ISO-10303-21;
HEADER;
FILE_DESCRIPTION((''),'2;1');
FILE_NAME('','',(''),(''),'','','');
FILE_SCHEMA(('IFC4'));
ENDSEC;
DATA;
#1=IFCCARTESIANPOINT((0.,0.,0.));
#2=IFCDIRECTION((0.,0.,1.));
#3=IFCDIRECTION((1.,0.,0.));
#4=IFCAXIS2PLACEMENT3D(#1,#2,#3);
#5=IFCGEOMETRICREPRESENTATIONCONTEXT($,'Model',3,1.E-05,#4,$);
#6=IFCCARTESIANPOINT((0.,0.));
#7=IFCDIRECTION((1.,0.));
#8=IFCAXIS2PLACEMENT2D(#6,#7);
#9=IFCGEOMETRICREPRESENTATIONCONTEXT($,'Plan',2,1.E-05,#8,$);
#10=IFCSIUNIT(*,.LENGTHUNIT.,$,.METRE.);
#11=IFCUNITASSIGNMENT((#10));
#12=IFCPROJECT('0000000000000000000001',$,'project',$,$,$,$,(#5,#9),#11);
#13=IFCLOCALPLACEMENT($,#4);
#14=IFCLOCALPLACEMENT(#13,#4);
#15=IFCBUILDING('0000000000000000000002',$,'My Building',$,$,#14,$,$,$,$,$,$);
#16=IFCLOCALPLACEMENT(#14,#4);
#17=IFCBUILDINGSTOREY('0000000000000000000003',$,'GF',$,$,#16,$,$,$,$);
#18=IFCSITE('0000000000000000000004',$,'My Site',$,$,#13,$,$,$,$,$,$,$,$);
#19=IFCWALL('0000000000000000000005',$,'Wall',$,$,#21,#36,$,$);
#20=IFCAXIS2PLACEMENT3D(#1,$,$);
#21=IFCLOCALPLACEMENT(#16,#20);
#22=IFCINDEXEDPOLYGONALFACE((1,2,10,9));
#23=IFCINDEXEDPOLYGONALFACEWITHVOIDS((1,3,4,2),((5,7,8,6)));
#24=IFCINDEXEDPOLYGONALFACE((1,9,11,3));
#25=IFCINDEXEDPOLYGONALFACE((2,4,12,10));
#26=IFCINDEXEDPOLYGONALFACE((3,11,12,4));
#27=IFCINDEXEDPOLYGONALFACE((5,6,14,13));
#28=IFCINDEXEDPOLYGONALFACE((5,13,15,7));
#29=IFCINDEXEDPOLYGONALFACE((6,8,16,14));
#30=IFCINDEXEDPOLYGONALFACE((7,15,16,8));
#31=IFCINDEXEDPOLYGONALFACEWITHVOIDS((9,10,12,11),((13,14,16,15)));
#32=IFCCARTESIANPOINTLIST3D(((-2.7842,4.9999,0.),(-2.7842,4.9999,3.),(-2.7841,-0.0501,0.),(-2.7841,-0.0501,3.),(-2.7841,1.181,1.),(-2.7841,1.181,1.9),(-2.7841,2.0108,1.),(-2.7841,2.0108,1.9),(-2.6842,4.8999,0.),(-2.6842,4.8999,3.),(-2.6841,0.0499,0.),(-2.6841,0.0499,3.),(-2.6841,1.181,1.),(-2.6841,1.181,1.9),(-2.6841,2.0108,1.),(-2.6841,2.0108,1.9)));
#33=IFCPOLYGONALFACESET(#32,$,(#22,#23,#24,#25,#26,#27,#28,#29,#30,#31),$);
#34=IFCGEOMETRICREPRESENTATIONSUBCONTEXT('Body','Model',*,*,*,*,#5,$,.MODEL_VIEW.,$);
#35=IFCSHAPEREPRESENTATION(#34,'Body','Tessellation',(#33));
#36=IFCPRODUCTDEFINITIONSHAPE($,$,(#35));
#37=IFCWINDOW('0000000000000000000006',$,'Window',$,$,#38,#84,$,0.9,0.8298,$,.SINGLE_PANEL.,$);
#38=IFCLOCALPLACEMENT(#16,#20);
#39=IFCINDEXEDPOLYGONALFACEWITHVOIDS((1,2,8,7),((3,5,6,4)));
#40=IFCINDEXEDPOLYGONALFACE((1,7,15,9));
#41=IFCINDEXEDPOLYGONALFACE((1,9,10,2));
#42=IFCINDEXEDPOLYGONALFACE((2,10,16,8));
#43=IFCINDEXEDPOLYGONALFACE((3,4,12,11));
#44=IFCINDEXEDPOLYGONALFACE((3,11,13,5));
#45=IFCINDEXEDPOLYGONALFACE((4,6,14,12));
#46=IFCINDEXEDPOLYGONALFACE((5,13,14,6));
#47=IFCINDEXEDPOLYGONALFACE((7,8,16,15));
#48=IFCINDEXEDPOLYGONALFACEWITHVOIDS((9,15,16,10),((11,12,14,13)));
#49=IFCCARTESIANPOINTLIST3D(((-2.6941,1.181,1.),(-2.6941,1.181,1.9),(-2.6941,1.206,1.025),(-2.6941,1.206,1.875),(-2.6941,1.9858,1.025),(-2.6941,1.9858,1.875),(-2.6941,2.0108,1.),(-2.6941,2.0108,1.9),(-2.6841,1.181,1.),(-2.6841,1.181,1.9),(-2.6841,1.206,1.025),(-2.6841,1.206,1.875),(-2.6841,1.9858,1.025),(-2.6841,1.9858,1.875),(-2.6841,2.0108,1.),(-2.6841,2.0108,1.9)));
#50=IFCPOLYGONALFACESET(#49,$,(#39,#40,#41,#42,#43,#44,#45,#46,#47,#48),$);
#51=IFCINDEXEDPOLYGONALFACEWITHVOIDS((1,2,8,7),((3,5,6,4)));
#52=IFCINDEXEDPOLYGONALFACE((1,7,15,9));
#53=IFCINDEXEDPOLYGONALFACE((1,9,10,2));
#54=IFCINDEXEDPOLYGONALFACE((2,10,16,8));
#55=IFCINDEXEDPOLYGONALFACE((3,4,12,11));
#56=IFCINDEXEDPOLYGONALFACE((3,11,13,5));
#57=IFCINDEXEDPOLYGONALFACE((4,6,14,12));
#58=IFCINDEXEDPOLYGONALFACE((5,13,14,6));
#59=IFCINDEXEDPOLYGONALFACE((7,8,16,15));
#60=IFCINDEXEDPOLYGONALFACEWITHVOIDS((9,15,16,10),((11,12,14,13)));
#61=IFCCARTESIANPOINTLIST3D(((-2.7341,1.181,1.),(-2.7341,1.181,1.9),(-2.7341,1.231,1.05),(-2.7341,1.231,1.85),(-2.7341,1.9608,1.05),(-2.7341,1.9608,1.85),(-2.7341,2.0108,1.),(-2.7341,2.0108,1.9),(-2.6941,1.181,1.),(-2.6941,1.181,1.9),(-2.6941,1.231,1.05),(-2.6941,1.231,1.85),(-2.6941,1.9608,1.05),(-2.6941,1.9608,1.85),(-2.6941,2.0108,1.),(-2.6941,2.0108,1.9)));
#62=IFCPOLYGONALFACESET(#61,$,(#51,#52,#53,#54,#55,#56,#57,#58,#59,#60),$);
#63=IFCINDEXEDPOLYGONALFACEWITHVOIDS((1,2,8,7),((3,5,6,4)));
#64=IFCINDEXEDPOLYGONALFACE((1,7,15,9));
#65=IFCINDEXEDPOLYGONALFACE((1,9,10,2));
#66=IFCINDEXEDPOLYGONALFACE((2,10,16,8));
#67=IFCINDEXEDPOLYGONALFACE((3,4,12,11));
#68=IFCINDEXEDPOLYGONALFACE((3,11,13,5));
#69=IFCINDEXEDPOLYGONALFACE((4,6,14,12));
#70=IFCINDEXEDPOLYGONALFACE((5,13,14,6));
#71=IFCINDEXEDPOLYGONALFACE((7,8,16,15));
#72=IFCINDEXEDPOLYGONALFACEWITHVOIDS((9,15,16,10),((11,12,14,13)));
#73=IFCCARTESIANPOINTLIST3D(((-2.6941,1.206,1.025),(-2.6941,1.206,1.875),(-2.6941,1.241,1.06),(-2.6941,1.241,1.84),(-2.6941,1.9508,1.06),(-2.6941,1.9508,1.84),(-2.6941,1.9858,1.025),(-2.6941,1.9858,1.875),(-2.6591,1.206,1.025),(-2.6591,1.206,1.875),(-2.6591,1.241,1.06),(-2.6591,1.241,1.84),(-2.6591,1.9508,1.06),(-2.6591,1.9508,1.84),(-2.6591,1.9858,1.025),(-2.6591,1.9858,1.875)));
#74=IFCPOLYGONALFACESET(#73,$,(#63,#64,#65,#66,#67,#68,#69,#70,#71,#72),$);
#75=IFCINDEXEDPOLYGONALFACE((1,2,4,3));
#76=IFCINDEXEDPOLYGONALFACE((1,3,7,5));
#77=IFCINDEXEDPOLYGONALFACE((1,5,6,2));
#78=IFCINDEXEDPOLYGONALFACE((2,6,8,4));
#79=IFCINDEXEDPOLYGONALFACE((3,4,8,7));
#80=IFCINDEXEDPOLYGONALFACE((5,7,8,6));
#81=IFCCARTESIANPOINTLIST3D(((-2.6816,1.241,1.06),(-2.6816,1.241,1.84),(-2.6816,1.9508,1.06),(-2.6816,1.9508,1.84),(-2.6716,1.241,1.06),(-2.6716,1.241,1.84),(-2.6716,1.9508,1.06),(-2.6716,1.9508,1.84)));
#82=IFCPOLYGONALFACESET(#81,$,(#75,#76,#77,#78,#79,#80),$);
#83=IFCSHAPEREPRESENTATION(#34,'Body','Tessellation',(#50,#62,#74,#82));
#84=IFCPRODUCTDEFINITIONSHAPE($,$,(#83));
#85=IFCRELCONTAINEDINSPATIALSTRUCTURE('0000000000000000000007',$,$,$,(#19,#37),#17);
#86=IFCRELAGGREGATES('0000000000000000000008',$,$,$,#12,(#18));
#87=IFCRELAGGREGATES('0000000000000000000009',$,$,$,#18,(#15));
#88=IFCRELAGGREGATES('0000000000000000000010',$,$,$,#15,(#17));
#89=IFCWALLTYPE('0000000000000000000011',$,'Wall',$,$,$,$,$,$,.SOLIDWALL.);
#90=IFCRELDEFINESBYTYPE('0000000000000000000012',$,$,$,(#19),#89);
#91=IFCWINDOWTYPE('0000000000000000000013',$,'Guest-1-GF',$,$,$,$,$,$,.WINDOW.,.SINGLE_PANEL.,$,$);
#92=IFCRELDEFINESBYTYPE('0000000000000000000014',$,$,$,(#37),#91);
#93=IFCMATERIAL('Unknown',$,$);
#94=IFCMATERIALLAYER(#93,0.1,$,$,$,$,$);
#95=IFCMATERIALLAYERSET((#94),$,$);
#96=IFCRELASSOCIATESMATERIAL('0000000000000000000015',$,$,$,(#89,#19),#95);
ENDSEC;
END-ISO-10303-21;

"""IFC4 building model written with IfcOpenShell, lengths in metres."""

from ifc_helpers import new_model, entity, si_unit, frame, origin_with_axes, origin_2d_with_axis, place, context, subcontext, project, spatial, line, indexed_curve, outline, extrude, shape, source, transform, mapped, material, layer, layer_set, layer_usage, type_object, type_shapes, element, fill, save


model = new_model("IFC4")

# Units and contexts
model_context = context("Model", 3, precision=1e-05, world=origin_with_axes())
plan_context = context("Plan", 2, precision=1e-05, world=origin_2d_with_axis())
body_context_1 = subcontext(model_context, "Body", "Model", "MODEL_VIEW")
body_context_2 = subcontext(plan_context, "Body", "Plan", "PLAN_VIEW")
ifc_project = project(units=[si_unit("LENGTHUNIT", "METRE")], contexts=[model_context, plan_context])

# Site, building, storey
site_placement = place(None, origin_with_axes())
site = spatial("IfcSite", under=ifc_project, at=site_placement, Name="My Site")
building_placement = place(site_placement, origin_with_axes())
building = spatial("IfcBuilding", under=site, at=building_placement, Name="My Building")
storey_placement = place(building_placement, origin_with_axes())
storey = spatial("IfcBuildingStorey", under=building, at=storey_placement, Name="GF")

# Shared definitions
ifc_material_1 = material(Name="Unknown")

# Shared definitions
ifc_layer_1 = layer(ifc_material_1, 0.1)
ifc_layer_set_1 = layer_set([ifc_layer_1])
wall_type = type_object("IfcWallType", Name="Wall", PredefinedType="SOLIDWALL", material=ifc_layer_set_1)

# Wall, opening, window
ifc_layer_usage_1 = layer_usage(ifc_layer_set_1, "AXIS2", "POSITIVE", 0.0)
wall_1_placement = place(storey_placement, frame((-2.7842, 4.9999, 0.0), z_axis=(0.0, 0.0, 1.0), x_axis=(0.0, -1.0, 0.0)))
wall_1 = element("IfcWall", 1, at=wall_1_placement, inside=storey, type_object=wall_type, material=ifc_layer_usage_1, Name="Wall", context=body_context_1, shape_type="SweptSolid", body=[
    extrude(outline(indexed_curve([(0.0, 0.0), (0.1, 0.1), (4.95, 0.1), (5.05, 0.0)], segments=[line(1, 2, 3, 4, 1)])), origin_with_axes(), (0.0, 0.0, 1.0), 3.0),
])
shared_shape_1 = source(origin_with_axes(), body_context_1, "Body", "SweptSolid", [
    extrude(outline(indexed_curve([(0.0, 0.0), (0.8298, 0.0), (0.8298, 0.9), (0.0, 0.9)], segments=[line(1, 2, 3, 4, 1)])), frame((0.0, -0.6, 0.0), z_axis=(0.0, -1.0, 0.0), x_axis=(1.0, 0.0, 0.0)), (0.0, 0.0, -1.0), 1.2),
])
opening_1_placement = place(wall_1_placement, frame((2.989, 0.0, 1.0), z_axis=(0.0, 0.0, 1.0), x_axis=(1.0, 0.0, 0.0)))
opening_1 = element("IfcOpeningElement", 2, at=opening_1_placement, cuts=wall_1, PredefinedType="OPENING", context=body_context_1, shape_type="MappedRepresentation", body=[
    mapped(shared_shape_1, transform((0.0, 0.0, 0.0), x_axis=(1.0, 0.0, 0.0), y_axis=(0.0, 1.0, 0.0), z_axis=(0.0, 0.0, 1.0), scale=1.0)),
])
window_type_1 = type_object("IfcWindowType", Name="Guest-1-GF", PartitioningType="SINGLE_PANEL", PredefinedType="WINDOW")
shared_shape_2 = source(origin_with_axes(), body_context_1, "Body", "SweptSolid", [
    extrude(outline(indexed_curve([(0.0, 0.0), (0.8298, 0.0), (0.8298, 0.9), (0.0, 0.9)], segments=[line(1, 2, 3, 4, 1)]), holes=[indexed_curve([(0.025, 0.025), (0.8048, 0.025), (0.8048, 0.875), (0.025, 0.875)], segments=[line(1, 2, 3, 4, 1)])]), frame((0.0, 0.09, 0.0), z_axis=(0.0, -1.0, 0.0), x_axis=(1.0, 0.0, 0.0)), (0.0, 0.0, -1.0), 0.01),
    extrude(outline(indexed_curve([(0.0, 0.0), (0.8298, 0.0), (0.8298, 0.9), (0.0, 0.9)], segments=[line(1, 2, 3, 4, 1)]), holes=[indexed_curve([(0.05, 0.05), (0.7798, 0.05), (0.7798, 0.85), (0.05, 0.85)], segments=[line(1, 2, 3, 4, 1)])]), frame((0.0, 0.05, 0.0), z_axis=(0.0, -1.0, 0.0), x_axis=(1.0, 0.0, 0.0)), (0.0, 0.0, -1.0), 0.04),
    extrude(outline(indexed_curve([(0.0, 0.0), (0.7798, 0.0), (0.7798, 0.85), (0.0, 0.85)], segments=[line(1, 2, 3, 4, 1)]), holes=[indexed_curve([(0.035, 0.035), (0.7448, 0.035), (0.7448, 0.815), (0.035, 0.815)], segments=[line(1, 2, 3, 4, 1)])]), frame((0.025, 0.09, 0.025), z_axis=(0.0, -1.0, 0.0), x_axis=(1.0, 0.0, 0.0)), (0.0, 0.0, -1.0), 0.035),
    extrude(outline(indexed_curve([(0.035, 0.035), (0.7448, 0.035), (0.7448, 0.815), (0.035, 0.815)], segments=[line(1, 2, 3, 4, 1)])), frame((0.025, 0.1025, 0.025), z_axis=(0.0, -1.0, 0.0), x_axis=(1.0, 0.0, 0.0)), (0.0, 0.0, -1.0), 0.01),
])
shared_shape_3 = source(origin_with_axes(), body_context_2, "Body", "Curve2D", [
    entity("IfcIndexedPolyCurve", entity("IfcCartesianPointList2D", [[0.05, 0.05], [0.7798, 0.05]])),
    entity("IfcIndexedPolyCurve", entity("IfcCartesianPointList2D", [[0.0, 0.1], [0.025, 0.1], [0.025, 0.09], [0.05, 0.09], [0.05, 0.05], [0.0, 0.05]]), [entity("IfcLineIndex", [1, 2, 3, 4, 5, 6, 1])]),
    entity("IfcIndexedPolyCurve", entity("IfcCartesianPointList2D", [[0.8298, 0.1], [0.8048, 0.1], [0.8048, 0.09], [0.7798, 0.09], [0.7798, 0.05], [0.8298, 0.05]]), [entity("IfcLineIndex", [1, 2, 3, 4, 5, 6, 1])]),
    entity("IfcIndexedPolyCurve", entity("IfcCartesianPointList2D", [[0.025, 0.09], [0.06, 0.09], [0.06, 0.125], [0.025, 0.125]]), [entity("IfcLineIndex", [1, 2, 3, 4, 1])]),
    entity("IfcIndexedPolyCurve", entity("IfcCartesianPointList2D", [[0.8048, 0.09], [0.7698, 0.09], [0.7698, 0.125], [0.8048, 0.125]]), [entity("IfcLineIndex", [1, 2, 3, 4, 1])]),
    entity("IfcIndexedPolyCurve", entity("IfcCartesianPointList2D", [[0.06, 0.09], [0.7698, 0.09]])),
    entity("IfcIndexedPolyCurve", entity("IfcCartesianPointList2D", [[0.06, 0.125], [0.7698, 0.125]])),
    entity("IfcIndexedPolyCurve", entity("IfcCartesianPointList2D", [[0.06, 0.1075], [0.7698, 0.1075]])),
])
type_shapes(window_type_1, [shared_shape_2, shared_shape_3])
window_1_placement = place(opening_1_placement, frame((0.0, 0.0, 0.0), z_axis=(0.0, 0.0, 1.0), x_axis=(1.0, 0.0, 0.0)))
window_1 = element("IfcWindow", 3, at=window_1_placement, inside=storey, type_object=window_type_1, Name="Window", OverallHeight=0.9, OverallWidth=0.8298, PartitioningType="SINGLE_PANEL", shapes=[
    shape(body_context_1, "Body", "MappedRepresentation", [mapped(shared_shape_2, transform((0.0, 0.0, 0.0), x_axis=(1.0, 0.0, 0.0), y_axis=(0.0, 1.0, 0.0), z_axis=(0.0, 0.0, 1.0), scale=1.0))]),
    shape(body_context_2, "Body", "MappedRepresentation", [mapped(shared_shape_3, transform((0.0, 0.0, 0.0), x_axis=(1.0, 0.0, 0.0), y_axis=(0.0, 1.0, 0.0), z_axis=(0.0, 0.0, 1.0), scale=1.0))]),
])
fill(opening_1, window_1)

save(model, "model.ifc")
